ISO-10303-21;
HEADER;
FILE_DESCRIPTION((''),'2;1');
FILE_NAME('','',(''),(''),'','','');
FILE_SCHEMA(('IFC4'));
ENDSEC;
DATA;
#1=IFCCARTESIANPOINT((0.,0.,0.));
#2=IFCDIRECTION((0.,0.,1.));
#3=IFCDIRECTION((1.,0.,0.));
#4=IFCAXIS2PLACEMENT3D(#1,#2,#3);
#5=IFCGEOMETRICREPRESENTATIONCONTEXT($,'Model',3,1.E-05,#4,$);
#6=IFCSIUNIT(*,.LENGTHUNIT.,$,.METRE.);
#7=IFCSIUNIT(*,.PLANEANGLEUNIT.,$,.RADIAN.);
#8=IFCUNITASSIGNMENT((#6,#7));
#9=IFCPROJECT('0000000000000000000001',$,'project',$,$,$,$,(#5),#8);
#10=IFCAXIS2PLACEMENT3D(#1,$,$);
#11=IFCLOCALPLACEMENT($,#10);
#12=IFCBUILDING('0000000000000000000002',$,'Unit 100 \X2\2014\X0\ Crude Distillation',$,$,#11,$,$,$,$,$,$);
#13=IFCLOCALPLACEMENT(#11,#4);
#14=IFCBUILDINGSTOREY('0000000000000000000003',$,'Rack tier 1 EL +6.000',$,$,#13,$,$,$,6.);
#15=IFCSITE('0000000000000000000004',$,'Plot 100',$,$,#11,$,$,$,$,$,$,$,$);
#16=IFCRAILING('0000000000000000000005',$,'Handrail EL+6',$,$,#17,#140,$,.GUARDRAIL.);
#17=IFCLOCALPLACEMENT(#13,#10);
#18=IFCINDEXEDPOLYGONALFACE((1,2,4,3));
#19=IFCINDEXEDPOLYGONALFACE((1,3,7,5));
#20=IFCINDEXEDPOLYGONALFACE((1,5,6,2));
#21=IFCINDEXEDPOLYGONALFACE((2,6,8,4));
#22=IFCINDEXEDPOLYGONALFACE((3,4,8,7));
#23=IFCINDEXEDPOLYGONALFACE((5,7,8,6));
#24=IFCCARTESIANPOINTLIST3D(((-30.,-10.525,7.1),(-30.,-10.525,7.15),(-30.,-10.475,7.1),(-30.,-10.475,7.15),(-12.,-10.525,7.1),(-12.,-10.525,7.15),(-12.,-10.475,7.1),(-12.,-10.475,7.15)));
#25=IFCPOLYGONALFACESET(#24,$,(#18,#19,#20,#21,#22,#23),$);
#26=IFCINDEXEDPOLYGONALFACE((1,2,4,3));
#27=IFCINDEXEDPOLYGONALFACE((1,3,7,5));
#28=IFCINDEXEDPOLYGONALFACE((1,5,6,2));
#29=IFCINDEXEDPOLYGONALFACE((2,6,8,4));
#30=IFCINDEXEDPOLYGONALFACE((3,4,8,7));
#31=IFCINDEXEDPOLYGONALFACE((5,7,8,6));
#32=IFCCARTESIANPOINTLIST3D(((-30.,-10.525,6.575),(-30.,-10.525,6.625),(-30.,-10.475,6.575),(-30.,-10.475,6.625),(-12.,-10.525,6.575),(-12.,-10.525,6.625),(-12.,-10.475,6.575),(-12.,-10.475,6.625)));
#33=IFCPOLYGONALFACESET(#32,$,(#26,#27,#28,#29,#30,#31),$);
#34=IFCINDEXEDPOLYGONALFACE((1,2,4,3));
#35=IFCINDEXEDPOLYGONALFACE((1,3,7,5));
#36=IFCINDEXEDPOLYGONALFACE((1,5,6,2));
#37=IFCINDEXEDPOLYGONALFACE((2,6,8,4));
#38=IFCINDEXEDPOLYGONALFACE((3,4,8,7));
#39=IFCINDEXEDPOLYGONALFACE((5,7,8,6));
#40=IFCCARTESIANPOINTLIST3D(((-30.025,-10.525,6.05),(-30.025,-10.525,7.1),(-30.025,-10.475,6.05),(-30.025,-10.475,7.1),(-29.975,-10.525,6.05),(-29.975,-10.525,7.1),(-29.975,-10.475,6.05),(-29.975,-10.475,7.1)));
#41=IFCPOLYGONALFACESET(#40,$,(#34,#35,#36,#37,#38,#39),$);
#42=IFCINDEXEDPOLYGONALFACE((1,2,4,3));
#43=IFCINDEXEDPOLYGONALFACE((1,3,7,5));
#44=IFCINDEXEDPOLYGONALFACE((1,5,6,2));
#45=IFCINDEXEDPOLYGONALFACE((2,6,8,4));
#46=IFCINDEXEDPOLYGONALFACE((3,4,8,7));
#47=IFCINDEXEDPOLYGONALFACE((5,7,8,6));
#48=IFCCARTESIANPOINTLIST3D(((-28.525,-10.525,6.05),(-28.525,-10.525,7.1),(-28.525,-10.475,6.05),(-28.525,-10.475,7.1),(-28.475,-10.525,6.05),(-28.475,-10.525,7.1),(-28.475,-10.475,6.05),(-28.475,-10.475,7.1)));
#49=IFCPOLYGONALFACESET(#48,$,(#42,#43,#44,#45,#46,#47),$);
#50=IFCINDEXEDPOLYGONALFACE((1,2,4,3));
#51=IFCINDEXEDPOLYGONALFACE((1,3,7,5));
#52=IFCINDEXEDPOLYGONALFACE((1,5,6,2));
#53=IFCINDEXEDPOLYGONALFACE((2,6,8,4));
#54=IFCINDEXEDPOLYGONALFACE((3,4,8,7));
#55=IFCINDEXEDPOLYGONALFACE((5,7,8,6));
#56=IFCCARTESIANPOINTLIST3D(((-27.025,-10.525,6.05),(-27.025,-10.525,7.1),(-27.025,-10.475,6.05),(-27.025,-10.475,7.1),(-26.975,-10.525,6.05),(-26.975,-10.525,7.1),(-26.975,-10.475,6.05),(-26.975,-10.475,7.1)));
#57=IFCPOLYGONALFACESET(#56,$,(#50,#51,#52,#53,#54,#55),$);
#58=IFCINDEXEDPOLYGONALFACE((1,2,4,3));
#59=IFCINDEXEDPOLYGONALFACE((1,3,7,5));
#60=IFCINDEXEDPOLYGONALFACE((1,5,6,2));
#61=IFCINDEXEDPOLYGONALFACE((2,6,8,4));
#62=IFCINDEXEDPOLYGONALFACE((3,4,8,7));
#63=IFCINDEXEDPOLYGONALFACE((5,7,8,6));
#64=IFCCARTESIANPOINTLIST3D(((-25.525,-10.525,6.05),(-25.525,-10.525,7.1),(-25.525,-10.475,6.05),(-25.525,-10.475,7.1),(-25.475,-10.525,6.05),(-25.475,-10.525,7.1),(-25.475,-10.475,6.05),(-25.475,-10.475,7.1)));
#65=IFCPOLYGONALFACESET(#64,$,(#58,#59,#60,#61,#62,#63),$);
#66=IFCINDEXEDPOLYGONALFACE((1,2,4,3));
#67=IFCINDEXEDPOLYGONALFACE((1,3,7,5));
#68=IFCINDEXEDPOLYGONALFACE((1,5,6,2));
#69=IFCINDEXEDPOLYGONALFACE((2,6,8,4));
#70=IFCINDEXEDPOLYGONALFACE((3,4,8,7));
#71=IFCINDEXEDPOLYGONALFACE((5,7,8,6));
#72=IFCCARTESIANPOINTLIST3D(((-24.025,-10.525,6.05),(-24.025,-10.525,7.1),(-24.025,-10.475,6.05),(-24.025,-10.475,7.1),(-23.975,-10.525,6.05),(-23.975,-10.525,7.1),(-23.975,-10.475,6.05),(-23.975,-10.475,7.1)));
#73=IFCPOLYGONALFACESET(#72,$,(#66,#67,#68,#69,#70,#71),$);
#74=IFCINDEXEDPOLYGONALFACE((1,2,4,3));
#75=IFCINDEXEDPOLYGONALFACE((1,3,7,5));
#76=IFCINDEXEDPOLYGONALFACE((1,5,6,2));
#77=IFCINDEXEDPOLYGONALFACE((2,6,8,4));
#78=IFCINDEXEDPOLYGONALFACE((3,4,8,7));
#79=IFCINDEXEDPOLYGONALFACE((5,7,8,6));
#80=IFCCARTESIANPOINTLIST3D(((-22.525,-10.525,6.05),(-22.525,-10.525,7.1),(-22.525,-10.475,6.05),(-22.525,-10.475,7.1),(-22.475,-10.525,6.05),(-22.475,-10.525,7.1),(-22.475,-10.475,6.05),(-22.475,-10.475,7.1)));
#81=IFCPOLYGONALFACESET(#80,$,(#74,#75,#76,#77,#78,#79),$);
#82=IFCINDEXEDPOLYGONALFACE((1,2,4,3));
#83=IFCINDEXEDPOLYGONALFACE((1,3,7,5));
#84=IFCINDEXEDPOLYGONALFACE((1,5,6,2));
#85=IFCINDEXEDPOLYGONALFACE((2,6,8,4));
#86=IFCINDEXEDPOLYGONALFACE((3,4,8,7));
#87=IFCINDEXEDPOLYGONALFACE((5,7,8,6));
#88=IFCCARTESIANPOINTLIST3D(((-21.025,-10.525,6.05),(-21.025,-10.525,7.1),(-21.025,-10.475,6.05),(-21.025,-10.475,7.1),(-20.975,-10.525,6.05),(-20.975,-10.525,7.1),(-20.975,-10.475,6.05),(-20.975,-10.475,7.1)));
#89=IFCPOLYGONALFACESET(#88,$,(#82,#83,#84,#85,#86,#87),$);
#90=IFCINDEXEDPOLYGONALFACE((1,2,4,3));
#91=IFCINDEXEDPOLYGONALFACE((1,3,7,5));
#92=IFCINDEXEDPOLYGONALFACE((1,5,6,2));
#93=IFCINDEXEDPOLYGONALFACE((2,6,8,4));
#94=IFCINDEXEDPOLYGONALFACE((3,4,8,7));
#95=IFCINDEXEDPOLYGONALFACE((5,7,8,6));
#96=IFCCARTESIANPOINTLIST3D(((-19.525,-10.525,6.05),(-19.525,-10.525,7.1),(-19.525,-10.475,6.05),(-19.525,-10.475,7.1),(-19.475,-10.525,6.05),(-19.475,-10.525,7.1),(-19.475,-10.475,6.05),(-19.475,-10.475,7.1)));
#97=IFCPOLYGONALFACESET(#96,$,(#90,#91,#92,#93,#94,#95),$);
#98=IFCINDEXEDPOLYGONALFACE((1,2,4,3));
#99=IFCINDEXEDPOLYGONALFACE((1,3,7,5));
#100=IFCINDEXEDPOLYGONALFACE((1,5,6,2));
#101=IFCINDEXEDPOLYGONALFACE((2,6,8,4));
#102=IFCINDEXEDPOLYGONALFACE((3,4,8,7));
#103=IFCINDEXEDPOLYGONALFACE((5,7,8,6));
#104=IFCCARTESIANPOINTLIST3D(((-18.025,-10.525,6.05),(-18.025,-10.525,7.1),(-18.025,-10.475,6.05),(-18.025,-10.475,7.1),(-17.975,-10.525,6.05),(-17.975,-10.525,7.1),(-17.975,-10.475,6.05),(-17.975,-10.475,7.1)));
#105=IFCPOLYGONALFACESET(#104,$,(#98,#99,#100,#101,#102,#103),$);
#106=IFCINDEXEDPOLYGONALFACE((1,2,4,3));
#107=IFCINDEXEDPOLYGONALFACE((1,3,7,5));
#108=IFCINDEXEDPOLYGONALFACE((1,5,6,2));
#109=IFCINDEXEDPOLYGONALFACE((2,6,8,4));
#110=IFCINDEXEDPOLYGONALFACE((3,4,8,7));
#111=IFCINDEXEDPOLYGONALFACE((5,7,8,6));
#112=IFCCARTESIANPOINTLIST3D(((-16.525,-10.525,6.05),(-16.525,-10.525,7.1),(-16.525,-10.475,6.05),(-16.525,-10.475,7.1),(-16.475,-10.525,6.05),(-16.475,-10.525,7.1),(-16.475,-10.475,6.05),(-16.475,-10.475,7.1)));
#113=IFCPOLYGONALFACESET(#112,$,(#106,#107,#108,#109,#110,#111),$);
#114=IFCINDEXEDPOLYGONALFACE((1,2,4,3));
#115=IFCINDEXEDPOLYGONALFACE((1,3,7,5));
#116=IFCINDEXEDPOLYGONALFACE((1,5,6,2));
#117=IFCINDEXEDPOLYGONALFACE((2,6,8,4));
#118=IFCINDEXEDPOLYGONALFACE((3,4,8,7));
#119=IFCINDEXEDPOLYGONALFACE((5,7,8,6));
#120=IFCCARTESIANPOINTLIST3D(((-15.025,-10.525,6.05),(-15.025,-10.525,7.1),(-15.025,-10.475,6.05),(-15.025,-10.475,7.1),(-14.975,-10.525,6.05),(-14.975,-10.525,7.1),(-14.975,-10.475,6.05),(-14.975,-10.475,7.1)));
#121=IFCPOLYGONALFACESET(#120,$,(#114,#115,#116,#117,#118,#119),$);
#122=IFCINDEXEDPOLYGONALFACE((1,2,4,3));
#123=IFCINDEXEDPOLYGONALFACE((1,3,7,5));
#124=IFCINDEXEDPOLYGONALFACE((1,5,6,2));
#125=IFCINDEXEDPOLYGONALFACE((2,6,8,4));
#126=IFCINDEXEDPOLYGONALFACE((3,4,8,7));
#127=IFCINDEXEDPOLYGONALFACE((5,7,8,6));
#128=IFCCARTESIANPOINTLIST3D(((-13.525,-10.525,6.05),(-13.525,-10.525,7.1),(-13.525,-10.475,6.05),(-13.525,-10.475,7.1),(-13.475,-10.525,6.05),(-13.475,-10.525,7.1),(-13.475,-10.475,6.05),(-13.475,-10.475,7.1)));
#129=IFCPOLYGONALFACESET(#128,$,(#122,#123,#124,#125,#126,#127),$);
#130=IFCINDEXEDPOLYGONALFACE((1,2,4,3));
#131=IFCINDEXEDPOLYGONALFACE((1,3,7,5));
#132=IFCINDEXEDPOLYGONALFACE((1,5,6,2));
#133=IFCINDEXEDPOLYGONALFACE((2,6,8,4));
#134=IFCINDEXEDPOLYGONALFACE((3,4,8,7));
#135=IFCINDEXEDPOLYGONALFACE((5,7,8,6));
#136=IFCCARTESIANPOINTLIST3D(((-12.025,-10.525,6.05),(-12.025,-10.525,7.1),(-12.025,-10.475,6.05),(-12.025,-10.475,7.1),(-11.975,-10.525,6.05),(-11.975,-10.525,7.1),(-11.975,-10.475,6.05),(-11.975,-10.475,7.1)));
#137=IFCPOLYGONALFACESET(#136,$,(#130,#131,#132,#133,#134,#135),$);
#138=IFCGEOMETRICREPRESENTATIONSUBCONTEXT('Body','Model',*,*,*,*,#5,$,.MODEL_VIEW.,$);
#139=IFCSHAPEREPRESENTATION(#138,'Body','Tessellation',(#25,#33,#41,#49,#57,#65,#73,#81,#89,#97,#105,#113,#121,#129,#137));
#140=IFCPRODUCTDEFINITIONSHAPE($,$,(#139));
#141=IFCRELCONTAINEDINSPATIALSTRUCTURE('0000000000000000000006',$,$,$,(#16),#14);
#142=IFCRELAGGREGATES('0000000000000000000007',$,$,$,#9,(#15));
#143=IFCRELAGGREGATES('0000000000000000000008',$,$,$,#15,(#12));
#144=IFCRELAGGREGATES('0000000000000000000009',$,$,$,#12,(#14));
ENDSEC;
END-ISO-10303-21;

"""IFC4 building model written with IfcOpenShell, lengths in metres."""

from ifc_helpers import new_model, si_unit, frame, origin, origin_with_axes, origin_2d, place, context, subcontext, project, spatial, rectangle, extrude, element, save


model = new_model("IFC4")

# Units and contexts
model_context = context("Model", 3, precision=1e-05, world=origin_with_axes())
body_context = subcontext(model_context, "Body", "Model", "MODEL_VIEW")
ifc_project = project(units=[si_unit("LENGTHUNIT", "METRE"), si_unit("PLANEANGLEUNIT", "RADIAN")], contexts=[model_context])

# Site, building, storey
placement = place(None, origin())
site = spatial("IfcSite", under=ifc_project, at=placement, Name="Plot 100")
building = spatial("IfcBuilding", under=site, at=placement, Name="Unit 100 — Crude Distillation")
storey_placement = place(placement, origin_with_axes())
storey = spatial("IfcBuildingStorey", under=building, at=storey_placement, Name="Rack tier 1 EL +6.000", Elevation=6.0)

# Railing
railing_1_placement = place(storey_placement, origin_with_axes())
element("IfcRailing", 1, at=railing_1_placement, inside=storey, Name="Handrail EL+6", PredefinedType="GUARDRAIL", context=body_context, shape_type="SweptSolid", body=[
    extrude(rectangle(XDim=0.05, YDim=0.05, at=origin_2d()), frame((-30.0, -10.5, 7.125), z_axis=(1.0, 0.0, 0.0), x_axis=(0.0, 1.0, 0.0)), (0.0, 0.0, 1.0), 18.0),
    extrude(rectangle(XDim=0.05, YDim=0.05, at=origin_2d()), frame((-30.0, -10.5, 6.6), z_axis=(1.0, 0.0, 0.0), x_axis=(0.0, 1.0, 0.0)), (0.0, 0.0, 1.0), 18.0),
    extrude(rectangle(XDim=0.05, YDim=0.05, at=origin_2d()), frame((-30.0, -10.5, 6.05), z_axis=(0.0, 0.0, 1.0), x_axis=(1.0, 0.0, 0.0)), (0.0, 0.0, 1.0), 1.05),
    extrude(rectangle(XDim=0.05, YDim=0.05, at=origin_2d()), frame((-28.5, -10.5, 6.05), z_axis=(0.0, 0.0, 1.0), x_axis=(1.0, 0.0, 0.0)), (0.0, 0.0, 1.0), 1.05),
    extrude(rectangle(XDim=0.05, YDim=0.05, at=origin_2d()), frame((-27.0, -10.5, 6.05), z_axis=(0.0, 0.0, 1.0), x_axis=(1.0, 0.0, 0.0)), (0.0, 0.0, 1.0), 1.05),
    extrude(rectangle(XDim=0.05, YDim=0.05, at=origin_2d()), frame((-25.5, -10.5, 6.05), z_axis=(0.0, 0.0, 1.0), x_axis=(1.0, 0.0, 0.0)), (0.0, 0.0, 1.0), 1.05),
    extrude(rectangle(XDim=0.05, YDim=0.05, at=origin_2d()), frame((-24.0, -10.5, 6.05), z_axis=(0.0, 0.0, 1.0), x_axis=(1.0, 0.0, 0.0)), (0.0, 0.0, 1.0), 1.05),
    extrude(rectangle(XDim=0.05, YDim=0.05, at=origin_2d()), frame((-22.5, -10.5, 6.05), z_axis=(0.0, 0.0, 1.0), x_axis=(1.0, 0.0, 0.0)), (0.0, 0.0, 1.0), 1.05),
    extrude(rectangle(XDim=0.05, YDim=0.05, at=origin_2d()), frame((-21.0, -10.5, 6.05), z_axis=(0.0, 0.0, 1.0), x_axis=(1.0, 0.0, 0.0)), (0.0, 0.0, 1.0), 1.05),
    extrude(rectangle(XDim=0.05, YDim=0.05, at=origin_2d()), frame((-19.5, -10.5, 6.05), z_axis=(0.0, 0.0, 1.0), x_axis=(1.0, 0.0, 0.0)), (0.0, 0.0, 1.0), 1.05),
    extrude(rectangle(XDim=0.05, YDim=0.05, at=origin_2d()), frame((-18.0, -10.5, 6.05), z_axis=(0.0, 0.0, 1.0), x_axis=(1.0, 0.0, 0.0)), (0.0, 0.0, 1.0), 1.05),
    extrude(rectangle(XDim=0.05, YDim=0.05, at=origin_2d()), frame((-16.5, -10.5, 6.05), z_axis=(0.0, 0.0, 1.0), x_axis=(1.0, 0.0, 0.0)), (0.0, 0.0, 1.0), 1.05),
    extrude(rectangle(XDim=0.05, YDim=0.05, at=origin_2d()), frame((-15.0, -10.5, 6.05), z_axis=(0.0, 0.0, 1.0), x_axis=(1.0, 0.0, 0.0)), (0.0, 0.0, 1.0), 1.05),
    extrude(rectangle(XDim=0.05, YDim=0.05, at=origin_2d()), frame((-13.5, -10.5, 6.05), z_axis=(0.0, 0.0, 1.0), x_axis=(1.0, 0.0, 0.0)), (0.0, 0.0, 1.0), 1.05),
    extrude(rectangle(XDim=0.05, YDim=0.05, at=origin_2d()), frame((-12.0, -10.5, 6.05), z_axis=(0.0, 0.0, 1.0), x_axis=(1.0, 0.0, 0.0)), (0.0, 0.0, 1.0), 1.05),
])

save(model, "model.ifc")
